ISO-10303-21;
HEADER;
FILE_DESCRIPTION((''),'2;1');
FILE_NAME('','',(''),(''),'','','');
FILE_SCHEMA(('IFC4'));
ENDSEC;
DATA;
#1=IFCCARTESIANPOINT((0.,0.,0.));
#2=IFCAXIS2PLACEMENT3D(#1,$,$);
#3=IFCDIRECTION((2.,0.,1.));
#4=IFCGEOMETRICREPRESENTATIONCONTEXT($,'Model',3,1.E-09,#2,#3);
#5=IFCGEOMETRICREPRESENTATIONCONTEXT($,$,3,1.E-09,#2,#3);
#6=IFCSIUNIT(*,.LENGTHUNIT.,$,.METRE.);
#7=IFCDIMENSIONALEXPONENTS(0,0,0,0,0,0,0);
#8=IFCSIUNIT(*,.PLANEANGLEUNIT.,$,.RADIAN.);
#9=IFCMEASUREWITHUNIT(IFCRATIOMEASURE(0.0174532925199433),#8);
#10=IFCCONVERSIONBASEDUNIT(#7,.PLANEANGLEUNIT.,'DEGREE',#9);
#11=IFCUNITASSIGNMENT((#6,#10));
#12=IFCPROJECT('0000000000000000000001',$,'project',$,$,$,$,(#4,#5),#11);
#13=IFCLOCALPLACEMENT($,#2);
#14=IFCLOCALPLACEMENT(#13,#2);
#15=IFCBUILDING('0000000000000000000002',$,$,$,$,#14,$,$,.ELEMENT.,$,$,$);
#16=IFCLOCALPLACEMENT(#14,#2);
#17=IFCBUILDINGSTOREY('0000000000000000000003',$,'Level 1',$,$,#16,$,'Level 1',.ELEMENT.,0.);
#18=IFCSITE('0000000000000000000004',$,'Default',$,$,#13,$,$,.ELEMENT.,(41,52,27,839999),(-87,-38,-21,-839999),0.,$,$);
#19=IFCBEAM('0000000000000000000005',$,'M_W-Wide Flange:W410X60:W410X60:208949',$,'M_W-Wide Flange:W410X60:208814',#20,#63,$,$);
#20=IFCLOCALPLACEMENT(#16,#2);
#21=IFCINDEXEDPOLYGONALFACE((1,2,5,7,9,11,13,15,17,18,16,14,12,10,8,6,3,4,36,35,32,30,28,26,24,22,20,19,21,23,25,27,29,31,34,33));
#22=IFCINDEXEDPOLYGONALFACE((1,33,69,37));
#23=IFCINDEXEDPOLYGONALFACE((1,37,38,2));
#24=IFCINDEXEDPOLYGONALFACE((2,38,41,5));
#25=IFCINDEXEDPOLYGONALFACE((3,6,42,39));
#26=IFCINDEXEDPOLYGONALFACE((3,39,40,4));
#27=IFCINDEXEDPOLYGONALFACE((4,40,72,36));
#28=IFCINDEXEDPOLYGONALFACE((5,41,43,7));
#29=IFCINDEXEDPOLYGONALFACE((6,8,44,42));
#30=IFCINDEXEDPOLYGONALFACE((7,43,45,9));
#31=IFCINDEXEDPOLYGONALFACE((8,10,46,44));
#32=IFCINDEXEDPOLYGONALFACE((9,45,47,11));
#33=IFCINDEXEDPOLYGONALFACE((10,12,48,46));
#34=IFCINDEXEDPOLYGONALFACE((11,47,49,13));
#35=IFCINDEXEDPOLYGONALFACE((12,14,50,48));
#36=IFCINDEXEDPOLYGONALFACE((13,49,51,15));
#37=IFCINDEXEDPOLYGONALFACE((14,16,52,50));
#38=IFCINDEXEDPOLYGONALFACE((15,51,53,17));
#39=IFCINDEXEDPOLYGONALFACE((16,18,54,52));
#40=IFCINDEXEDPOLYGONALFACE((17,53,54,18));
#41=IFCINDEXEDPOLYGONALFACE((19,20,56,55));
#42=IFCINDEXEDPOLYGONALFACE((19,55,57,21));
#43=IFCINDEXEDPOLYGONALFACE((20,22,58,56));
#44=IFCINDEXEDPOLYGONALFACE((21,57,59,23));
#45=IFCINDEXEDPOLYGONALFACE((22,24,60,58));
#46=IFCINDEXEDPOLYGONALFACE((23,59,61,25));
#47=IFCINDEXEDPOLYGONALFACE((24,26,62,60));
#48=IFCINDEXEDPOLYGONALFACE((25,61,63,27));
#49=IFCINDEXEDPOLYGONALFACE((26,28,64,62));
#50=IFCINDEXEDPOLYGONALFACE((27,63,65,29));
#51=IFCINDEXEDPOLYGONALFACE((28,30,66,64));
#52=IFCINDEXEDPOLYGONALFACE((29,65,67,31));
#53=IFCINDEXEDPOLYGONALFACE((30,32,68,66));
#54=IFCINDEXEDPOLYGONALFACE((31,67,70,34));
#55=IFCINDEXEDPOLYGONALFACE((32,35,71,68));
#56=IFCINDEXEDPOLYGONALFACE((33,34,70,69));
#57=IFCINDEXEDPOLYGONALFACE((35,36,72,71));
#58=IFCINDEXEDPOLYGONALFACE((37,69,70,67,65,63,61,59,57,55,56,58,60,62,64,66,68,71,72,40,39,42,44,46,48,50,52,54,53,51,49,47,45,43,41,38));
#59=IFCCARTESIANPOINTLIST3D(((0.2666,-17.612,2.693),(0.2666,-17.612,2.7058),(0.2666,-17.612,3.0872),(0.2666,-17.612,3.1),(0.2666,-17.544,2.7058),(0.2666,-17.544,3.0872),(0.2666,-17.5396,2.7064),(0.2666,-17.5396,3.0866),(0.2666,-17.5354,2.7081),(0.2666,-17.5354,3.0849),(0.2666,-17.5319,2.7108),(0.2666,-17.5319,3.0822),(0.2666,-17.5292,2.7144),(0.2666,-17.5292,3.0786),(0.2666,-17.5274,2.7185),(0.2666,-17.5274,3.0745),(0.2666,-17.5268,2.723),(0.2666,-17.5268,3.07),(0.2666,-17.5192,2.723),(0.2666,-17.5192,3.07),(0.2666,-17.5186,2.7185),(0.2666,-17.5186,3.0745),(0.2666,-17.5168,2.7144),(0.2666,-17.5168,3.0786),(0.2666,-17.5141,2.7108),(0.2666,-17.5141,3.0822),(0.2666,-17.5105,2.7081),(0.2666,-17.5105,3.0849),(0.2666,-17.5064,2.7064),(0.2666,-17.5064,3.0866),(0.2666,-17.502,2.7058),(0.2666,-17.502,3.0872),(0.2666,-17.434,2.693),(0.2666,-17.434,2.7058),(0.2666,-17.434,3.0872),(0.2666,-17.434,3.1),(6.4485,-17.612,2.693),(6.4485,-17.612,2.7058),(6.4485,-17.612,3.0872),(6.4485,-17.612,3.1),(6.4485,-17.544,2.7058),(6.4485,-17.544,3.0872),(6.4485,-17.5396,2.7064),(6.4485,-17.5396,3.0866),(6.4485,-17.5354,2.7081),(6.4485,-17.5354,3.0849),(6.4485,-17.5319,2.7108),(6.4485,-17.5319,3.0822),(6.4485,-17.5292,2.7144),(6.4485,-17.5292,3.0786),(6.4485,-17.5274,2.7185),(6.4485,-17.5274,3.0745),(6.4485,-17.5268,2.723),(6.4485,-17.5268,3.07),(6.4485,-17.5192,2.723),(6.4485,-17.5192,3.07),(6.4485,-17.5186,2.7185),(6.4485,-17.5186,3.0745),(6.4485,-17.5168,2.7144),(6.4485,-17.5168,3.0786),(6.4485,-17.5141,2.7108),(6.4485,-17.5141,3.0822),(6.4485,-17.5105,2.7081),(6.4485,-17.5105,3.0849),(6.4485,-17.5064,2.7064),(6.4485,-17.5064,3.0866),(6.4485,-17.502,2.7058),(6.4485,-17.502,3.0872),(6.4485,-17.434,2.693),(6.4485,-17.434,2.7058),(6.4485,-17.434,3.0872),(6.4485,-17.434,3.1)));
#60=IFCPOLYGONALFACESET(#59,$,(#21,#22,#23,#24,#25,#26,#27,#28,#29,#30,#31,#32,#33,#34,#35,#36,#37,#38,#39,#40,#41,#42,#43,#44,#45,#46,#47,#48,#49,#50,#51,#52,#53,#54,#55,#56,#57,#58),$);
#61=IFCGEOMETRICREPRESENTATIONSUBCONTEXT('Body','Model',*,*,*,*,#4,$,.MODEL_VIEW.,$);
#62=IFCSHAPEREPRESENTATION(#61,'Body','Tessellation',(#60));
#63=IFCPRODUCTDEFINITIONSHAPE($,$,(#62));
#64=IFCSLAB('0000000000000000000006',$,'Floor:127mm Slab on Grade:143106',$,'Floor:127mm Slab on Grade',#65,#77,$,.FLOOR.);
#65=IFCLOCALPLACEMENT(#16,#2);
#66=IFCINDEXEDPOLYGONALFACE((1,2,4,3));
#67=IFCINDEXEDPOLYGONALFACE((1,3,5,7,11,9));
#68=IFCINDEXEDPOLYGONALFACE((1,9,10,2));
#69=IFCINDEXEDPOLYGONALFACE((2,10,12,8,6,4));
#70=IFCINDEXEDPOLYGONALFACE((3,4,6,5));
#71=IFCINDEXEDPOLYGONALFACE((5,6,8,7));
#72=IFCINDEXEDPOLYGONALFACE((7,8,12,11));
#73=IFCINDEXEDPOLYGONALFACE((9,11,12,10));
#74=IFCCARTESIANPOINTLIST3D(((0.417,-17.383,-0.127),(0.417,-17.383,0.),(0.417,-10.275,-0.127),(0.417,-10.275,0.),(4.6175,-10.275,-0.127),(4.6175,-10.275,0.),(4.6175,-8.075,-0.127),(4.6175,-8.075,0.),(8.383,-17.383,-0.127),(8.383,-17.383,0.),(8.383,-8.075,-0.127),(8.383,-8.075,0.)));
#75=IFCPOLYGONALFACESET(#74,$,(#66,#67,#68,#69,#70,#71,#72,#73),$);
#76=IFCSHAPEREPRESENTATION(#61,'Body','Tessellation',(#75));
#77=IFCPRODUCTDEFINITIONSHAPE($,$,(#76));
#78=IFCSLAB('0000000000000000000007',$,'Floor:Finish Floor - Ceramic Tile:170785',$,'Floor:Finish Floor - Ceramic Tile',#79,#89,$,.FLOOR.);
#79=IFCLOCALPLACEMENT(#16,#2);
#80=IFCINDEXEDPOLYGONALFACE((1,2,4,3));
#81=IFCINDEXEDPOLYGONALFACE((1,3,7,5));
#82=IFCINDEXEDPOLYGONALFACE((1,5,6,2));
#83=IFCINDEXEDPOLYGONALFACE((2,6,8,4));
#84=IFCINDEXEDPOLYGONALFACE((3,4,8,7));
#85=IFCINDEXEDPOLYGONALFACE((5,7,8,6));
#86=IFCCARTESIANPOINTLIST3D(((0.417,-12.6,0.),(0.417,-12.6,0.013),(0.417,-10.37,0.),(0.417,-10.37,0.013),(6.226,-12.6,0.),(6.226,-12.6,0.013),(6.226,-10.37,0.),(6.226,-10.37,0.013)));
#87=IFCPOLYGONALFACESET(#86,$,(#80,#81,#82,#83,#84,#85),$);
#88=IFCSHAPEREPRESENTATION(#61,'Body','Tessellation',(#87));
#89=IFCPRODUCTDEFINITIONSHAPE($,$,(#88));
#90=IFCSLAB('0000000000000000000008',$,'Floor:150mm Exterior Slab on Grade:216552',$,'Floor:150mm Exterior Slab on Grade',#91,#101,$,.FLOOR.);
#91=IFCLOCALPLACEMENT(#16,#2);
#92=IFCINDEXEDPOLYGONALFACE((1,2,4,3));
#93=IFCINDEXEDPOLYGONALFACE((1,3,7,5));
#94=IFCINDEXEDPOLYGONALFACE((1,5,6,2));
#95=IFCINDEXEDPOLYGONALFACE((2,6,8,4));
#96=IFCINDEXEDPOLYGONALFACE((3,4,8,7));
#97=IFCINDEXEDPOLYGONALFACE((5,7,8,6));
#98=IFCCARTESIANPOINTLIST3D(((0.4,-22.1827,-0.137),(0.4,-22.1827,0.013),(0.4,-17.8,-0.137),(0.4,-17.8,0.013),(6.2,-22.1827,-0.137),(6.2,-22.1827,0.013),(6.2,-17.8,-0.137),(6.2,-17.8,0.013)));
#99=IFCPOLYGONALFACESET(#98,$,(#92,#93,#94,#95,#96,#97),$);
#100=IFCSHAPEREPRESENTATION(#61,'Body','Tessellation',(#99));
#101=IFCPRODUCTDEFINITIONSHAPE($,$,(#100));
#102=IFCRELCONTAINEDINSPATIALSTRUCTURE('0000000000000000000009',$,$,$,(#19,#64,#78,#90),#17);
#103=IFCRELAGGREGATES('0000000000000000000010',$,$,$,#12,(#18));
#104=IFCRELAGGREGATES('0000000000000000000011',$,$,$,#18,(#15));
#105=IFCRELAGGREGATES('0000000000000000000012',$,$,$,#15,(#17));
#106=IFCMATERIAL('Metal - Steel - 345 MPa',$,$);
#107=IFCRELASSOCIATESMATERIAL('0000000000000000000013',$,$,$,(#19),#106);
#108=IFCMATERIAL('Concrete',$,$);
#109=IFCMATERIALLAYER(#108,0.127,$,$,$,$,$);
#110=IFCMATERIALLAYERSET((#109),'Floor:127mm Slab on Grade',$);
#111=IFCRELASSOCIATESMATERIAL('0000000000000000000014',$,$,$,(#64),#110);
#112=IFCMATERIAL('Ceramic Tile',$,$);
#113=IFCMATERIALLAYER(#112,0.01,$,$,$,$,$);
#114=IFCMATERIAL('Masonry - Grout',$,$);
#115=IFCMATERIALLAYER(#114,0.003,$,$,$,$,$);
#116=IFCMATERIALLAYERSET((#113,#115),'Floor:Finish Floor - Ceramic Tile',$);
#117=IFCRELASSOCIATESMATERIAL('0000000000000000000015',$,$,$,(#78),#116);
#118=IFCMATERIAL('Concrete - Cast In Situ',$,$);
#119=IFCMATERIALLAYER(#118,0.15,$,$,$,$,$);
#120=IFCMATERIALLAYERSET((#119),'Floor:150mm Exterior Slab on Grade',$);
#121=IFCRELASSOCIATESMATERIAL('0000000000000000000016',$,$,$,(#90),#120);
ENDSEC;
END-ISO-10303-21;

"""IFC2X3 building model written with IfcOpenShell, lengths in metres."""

from ifc_helpers import new_model, entity, si_unit, converted_unit, direction, frame, frame_2d, origin, origin_2d_with_axis, place, context, subcontext, project, spatial, polyline, rectangle, i_section, outline, extrude, material, layer, layer_set, layer_usage, element, save


model = new_model("IFC2X3")

# Units and contexts
model_context = context("Model", 3, precision=1e-09, world=origin(), true_north=direction((2.0, 0.0, 1.0)))
context_of_model = context(None, 3, precision=1e-09, world=origin(), true_north=direction((2.0, 0.0, 1.0)))
body_context = subcontext(model_context, "Body", "Model", "MODEL_VIEW")
ifc_project = project(units=[si_unit("LENGTHUNIT", "METRE"), converted_unit("PLANEANGLEUNIT", "DEGREE", entity("IfcRatioMeasure", 0.0174532925199433), si_unit("PLANEANGLEUNIT", "RADIAN"), dimensions=[0, 0, 0, 0, 0, 0, 0])], contexts=[model_context, context_of_model])

# Site, building, storey
site_placement = place(None, origin())
site = spatial("IfcSite", under=ifc_project, at=site_placement, Name="Default", CompositionType="ELEMENT", RefLatitude=(41, 52, 27, 839999), RefLongitude=(-87, -38, -21, -839999), RefElevation=0.0)
building_placement = place(site_placement, origin())
building = spatial("IfcBuilding", under=site, at=building_placement, CompositionType="ELEMENT")
storey_placement = place(building_placement, origin())
storey = spatial("IfcBuildingStorey", under=building, at=storey_placement, Name="Level 1", LongName="Level 1", CompositionType="ELEMENT", Elevation=0.0)

# Beam
ifc_material_1 = material(Name="Metal - Steel - 345 MPa")
beam_placement = place(storey_placement, frame((0.2085, -17.523, 3.1)))
element("IfcBeam", 1, at=beam_placement, inside=storey, material=ifc_material_1, Name="M_W-Wide Flange:W410X60:W410X60:208949", ObjectType="M_W-Wide Flange:W410X60:208814", context=body_context, shape_type="SweptSolid", body=[
    extrude(i_section(OverallWidth=0.178, OverallDepth=0.407, WebThickness=0.0077, FlangeThickness=0.0128, FilletRadius=0.0172, at=frame_2d((0.0, 0.0), x_axis=(1.0, 0.0))), frame((0.0581, 0.0, -0.2035), z_axis=(-1.0, 0.0, 0.0), x_axis=(0.0, -1.0, 0.0)), (0.0, 0.0, -1.0), 6.1819),
])

# Slabs
ifc_material_2 = material(Name="Concrete")
ifc_layer_1 = layer(ifc_material_2, 0.127)
ifc_layer_set_1 = layer_set([ifc_layer_1], Name="Floor:127mm Slab on Grade")
ifc_layer_usage_1 = layer_usage(ifc_layer_set_1, "AXIS3", "POSITIVE", 0.0)
slab_1_placement = place(storey_placement, frame((0.417, -17.383, -0.127)))
element("IfcSlab", 2, at=slab_1_placement, inside=storey, material=ifc_layer_usage_1, Name="Floor:127mm Slab on Grade:143106", ObjectType="Floor:127mm Slab on Grade", PredefinedType="FLOOR", context=body_context, shape_type="SweptSolid", body=[
    extrude(outline(polyline([(-3.983, 4.654), (-3.983, -4.654), (3.983, -4.654), (3.983, 2.454), (-0.2175, 2.454), (-0.2175, 4.654), (-3.983, 4.654)])), frame((3.983, 4.654, 0.127), z_axis=(0.0, 0.0, -1.0), x_axis=(-1.0, 0.0, 0.0)), (0.0, 0.0, 1.0), 0.127),
])
ifc_material_3 = material(Name="Ceramic Tile")
ifc_layer_2 = layer(ifc_material_3, 0.01)
ifc_material_4 = material(Name="Masonry - Grout")
ifc_layer_3 = layer(ifc_material_4, 0.003)
ifc_layer_set_2 = layer_set([ifc_layer_2, ifc_layer_3], Name="Floor:Finish Floor - Ceramic Tile")
ifc_layer_usage_2 = layer_usage(ifc_layer_set_2, "AXIS3", "POSITIVE", 0.0)
slab_2_placement = place(storey_placement, frame((0.417, -12.6, 0.0)))
element("IfcSlab", 3, at=slab_2_placement, inside=storey, material=ifc_layer_usage_2, Name="Floor:Finish Floor - Ceramic Tile:170785", ObjectType="Floor:Finish Floor - Ceramic Tile", PredefinedType="FLOOR", context=body_context, shape_type="SweptSolid", body=[
    extrude(rectangle(XDim=5.809, YDim=2.23, at=frame_2d((0.0, 0.0), x_axis=(-1.0, 0.0))), frame((2.9045, 1.115, 0.013), z_axis=(0.0, 0.0, -1.0), x_axis=(-1.0, 0.0, 0.0)), (0.0, 0.0, 1.0), 0.013),
])
ifc_material_5 = material(Name="Concrete - Cast In Situ")
ifc_layer_4 = layer(ifc_material_5, 0.15)
ifc_layer_set_3 = layer_set([ifc_layer_4], Name="Floor:150mm Exterior Slab on Grade")
ifc_layer_usage_3 = layer_usage(ifc_layer_set_3, "AXIS3", "POSITIVE", 0.0)
slab_3_placement = place(storey_placement, frame((0.4, -22.1827, -0.137)))
element("IfcSlab", 4, at=slab_3_placement, inside=storey, material=ifc_layer_usage_3, Name="Floor:150mm Exterior Slab on Grade:216552", ObjectType="Floor:150mm Exterior Slab on Grade", PredefinedType="FLOOR", context=body_context, shape_type="SweptSolid", body=[
    extrude(rectangle(XDim=5.8, YDim=4.3827, at=origin_2d_with_axis()), frame((2.9, 2.1914, 0.15), z_axis=(0.0, 0.0, -1.0), x_axis=(-1.0, 0.0, 0.0)), (0.0, 0.0, 1.0), 0.15),
])

save(model, "model.ifc")
